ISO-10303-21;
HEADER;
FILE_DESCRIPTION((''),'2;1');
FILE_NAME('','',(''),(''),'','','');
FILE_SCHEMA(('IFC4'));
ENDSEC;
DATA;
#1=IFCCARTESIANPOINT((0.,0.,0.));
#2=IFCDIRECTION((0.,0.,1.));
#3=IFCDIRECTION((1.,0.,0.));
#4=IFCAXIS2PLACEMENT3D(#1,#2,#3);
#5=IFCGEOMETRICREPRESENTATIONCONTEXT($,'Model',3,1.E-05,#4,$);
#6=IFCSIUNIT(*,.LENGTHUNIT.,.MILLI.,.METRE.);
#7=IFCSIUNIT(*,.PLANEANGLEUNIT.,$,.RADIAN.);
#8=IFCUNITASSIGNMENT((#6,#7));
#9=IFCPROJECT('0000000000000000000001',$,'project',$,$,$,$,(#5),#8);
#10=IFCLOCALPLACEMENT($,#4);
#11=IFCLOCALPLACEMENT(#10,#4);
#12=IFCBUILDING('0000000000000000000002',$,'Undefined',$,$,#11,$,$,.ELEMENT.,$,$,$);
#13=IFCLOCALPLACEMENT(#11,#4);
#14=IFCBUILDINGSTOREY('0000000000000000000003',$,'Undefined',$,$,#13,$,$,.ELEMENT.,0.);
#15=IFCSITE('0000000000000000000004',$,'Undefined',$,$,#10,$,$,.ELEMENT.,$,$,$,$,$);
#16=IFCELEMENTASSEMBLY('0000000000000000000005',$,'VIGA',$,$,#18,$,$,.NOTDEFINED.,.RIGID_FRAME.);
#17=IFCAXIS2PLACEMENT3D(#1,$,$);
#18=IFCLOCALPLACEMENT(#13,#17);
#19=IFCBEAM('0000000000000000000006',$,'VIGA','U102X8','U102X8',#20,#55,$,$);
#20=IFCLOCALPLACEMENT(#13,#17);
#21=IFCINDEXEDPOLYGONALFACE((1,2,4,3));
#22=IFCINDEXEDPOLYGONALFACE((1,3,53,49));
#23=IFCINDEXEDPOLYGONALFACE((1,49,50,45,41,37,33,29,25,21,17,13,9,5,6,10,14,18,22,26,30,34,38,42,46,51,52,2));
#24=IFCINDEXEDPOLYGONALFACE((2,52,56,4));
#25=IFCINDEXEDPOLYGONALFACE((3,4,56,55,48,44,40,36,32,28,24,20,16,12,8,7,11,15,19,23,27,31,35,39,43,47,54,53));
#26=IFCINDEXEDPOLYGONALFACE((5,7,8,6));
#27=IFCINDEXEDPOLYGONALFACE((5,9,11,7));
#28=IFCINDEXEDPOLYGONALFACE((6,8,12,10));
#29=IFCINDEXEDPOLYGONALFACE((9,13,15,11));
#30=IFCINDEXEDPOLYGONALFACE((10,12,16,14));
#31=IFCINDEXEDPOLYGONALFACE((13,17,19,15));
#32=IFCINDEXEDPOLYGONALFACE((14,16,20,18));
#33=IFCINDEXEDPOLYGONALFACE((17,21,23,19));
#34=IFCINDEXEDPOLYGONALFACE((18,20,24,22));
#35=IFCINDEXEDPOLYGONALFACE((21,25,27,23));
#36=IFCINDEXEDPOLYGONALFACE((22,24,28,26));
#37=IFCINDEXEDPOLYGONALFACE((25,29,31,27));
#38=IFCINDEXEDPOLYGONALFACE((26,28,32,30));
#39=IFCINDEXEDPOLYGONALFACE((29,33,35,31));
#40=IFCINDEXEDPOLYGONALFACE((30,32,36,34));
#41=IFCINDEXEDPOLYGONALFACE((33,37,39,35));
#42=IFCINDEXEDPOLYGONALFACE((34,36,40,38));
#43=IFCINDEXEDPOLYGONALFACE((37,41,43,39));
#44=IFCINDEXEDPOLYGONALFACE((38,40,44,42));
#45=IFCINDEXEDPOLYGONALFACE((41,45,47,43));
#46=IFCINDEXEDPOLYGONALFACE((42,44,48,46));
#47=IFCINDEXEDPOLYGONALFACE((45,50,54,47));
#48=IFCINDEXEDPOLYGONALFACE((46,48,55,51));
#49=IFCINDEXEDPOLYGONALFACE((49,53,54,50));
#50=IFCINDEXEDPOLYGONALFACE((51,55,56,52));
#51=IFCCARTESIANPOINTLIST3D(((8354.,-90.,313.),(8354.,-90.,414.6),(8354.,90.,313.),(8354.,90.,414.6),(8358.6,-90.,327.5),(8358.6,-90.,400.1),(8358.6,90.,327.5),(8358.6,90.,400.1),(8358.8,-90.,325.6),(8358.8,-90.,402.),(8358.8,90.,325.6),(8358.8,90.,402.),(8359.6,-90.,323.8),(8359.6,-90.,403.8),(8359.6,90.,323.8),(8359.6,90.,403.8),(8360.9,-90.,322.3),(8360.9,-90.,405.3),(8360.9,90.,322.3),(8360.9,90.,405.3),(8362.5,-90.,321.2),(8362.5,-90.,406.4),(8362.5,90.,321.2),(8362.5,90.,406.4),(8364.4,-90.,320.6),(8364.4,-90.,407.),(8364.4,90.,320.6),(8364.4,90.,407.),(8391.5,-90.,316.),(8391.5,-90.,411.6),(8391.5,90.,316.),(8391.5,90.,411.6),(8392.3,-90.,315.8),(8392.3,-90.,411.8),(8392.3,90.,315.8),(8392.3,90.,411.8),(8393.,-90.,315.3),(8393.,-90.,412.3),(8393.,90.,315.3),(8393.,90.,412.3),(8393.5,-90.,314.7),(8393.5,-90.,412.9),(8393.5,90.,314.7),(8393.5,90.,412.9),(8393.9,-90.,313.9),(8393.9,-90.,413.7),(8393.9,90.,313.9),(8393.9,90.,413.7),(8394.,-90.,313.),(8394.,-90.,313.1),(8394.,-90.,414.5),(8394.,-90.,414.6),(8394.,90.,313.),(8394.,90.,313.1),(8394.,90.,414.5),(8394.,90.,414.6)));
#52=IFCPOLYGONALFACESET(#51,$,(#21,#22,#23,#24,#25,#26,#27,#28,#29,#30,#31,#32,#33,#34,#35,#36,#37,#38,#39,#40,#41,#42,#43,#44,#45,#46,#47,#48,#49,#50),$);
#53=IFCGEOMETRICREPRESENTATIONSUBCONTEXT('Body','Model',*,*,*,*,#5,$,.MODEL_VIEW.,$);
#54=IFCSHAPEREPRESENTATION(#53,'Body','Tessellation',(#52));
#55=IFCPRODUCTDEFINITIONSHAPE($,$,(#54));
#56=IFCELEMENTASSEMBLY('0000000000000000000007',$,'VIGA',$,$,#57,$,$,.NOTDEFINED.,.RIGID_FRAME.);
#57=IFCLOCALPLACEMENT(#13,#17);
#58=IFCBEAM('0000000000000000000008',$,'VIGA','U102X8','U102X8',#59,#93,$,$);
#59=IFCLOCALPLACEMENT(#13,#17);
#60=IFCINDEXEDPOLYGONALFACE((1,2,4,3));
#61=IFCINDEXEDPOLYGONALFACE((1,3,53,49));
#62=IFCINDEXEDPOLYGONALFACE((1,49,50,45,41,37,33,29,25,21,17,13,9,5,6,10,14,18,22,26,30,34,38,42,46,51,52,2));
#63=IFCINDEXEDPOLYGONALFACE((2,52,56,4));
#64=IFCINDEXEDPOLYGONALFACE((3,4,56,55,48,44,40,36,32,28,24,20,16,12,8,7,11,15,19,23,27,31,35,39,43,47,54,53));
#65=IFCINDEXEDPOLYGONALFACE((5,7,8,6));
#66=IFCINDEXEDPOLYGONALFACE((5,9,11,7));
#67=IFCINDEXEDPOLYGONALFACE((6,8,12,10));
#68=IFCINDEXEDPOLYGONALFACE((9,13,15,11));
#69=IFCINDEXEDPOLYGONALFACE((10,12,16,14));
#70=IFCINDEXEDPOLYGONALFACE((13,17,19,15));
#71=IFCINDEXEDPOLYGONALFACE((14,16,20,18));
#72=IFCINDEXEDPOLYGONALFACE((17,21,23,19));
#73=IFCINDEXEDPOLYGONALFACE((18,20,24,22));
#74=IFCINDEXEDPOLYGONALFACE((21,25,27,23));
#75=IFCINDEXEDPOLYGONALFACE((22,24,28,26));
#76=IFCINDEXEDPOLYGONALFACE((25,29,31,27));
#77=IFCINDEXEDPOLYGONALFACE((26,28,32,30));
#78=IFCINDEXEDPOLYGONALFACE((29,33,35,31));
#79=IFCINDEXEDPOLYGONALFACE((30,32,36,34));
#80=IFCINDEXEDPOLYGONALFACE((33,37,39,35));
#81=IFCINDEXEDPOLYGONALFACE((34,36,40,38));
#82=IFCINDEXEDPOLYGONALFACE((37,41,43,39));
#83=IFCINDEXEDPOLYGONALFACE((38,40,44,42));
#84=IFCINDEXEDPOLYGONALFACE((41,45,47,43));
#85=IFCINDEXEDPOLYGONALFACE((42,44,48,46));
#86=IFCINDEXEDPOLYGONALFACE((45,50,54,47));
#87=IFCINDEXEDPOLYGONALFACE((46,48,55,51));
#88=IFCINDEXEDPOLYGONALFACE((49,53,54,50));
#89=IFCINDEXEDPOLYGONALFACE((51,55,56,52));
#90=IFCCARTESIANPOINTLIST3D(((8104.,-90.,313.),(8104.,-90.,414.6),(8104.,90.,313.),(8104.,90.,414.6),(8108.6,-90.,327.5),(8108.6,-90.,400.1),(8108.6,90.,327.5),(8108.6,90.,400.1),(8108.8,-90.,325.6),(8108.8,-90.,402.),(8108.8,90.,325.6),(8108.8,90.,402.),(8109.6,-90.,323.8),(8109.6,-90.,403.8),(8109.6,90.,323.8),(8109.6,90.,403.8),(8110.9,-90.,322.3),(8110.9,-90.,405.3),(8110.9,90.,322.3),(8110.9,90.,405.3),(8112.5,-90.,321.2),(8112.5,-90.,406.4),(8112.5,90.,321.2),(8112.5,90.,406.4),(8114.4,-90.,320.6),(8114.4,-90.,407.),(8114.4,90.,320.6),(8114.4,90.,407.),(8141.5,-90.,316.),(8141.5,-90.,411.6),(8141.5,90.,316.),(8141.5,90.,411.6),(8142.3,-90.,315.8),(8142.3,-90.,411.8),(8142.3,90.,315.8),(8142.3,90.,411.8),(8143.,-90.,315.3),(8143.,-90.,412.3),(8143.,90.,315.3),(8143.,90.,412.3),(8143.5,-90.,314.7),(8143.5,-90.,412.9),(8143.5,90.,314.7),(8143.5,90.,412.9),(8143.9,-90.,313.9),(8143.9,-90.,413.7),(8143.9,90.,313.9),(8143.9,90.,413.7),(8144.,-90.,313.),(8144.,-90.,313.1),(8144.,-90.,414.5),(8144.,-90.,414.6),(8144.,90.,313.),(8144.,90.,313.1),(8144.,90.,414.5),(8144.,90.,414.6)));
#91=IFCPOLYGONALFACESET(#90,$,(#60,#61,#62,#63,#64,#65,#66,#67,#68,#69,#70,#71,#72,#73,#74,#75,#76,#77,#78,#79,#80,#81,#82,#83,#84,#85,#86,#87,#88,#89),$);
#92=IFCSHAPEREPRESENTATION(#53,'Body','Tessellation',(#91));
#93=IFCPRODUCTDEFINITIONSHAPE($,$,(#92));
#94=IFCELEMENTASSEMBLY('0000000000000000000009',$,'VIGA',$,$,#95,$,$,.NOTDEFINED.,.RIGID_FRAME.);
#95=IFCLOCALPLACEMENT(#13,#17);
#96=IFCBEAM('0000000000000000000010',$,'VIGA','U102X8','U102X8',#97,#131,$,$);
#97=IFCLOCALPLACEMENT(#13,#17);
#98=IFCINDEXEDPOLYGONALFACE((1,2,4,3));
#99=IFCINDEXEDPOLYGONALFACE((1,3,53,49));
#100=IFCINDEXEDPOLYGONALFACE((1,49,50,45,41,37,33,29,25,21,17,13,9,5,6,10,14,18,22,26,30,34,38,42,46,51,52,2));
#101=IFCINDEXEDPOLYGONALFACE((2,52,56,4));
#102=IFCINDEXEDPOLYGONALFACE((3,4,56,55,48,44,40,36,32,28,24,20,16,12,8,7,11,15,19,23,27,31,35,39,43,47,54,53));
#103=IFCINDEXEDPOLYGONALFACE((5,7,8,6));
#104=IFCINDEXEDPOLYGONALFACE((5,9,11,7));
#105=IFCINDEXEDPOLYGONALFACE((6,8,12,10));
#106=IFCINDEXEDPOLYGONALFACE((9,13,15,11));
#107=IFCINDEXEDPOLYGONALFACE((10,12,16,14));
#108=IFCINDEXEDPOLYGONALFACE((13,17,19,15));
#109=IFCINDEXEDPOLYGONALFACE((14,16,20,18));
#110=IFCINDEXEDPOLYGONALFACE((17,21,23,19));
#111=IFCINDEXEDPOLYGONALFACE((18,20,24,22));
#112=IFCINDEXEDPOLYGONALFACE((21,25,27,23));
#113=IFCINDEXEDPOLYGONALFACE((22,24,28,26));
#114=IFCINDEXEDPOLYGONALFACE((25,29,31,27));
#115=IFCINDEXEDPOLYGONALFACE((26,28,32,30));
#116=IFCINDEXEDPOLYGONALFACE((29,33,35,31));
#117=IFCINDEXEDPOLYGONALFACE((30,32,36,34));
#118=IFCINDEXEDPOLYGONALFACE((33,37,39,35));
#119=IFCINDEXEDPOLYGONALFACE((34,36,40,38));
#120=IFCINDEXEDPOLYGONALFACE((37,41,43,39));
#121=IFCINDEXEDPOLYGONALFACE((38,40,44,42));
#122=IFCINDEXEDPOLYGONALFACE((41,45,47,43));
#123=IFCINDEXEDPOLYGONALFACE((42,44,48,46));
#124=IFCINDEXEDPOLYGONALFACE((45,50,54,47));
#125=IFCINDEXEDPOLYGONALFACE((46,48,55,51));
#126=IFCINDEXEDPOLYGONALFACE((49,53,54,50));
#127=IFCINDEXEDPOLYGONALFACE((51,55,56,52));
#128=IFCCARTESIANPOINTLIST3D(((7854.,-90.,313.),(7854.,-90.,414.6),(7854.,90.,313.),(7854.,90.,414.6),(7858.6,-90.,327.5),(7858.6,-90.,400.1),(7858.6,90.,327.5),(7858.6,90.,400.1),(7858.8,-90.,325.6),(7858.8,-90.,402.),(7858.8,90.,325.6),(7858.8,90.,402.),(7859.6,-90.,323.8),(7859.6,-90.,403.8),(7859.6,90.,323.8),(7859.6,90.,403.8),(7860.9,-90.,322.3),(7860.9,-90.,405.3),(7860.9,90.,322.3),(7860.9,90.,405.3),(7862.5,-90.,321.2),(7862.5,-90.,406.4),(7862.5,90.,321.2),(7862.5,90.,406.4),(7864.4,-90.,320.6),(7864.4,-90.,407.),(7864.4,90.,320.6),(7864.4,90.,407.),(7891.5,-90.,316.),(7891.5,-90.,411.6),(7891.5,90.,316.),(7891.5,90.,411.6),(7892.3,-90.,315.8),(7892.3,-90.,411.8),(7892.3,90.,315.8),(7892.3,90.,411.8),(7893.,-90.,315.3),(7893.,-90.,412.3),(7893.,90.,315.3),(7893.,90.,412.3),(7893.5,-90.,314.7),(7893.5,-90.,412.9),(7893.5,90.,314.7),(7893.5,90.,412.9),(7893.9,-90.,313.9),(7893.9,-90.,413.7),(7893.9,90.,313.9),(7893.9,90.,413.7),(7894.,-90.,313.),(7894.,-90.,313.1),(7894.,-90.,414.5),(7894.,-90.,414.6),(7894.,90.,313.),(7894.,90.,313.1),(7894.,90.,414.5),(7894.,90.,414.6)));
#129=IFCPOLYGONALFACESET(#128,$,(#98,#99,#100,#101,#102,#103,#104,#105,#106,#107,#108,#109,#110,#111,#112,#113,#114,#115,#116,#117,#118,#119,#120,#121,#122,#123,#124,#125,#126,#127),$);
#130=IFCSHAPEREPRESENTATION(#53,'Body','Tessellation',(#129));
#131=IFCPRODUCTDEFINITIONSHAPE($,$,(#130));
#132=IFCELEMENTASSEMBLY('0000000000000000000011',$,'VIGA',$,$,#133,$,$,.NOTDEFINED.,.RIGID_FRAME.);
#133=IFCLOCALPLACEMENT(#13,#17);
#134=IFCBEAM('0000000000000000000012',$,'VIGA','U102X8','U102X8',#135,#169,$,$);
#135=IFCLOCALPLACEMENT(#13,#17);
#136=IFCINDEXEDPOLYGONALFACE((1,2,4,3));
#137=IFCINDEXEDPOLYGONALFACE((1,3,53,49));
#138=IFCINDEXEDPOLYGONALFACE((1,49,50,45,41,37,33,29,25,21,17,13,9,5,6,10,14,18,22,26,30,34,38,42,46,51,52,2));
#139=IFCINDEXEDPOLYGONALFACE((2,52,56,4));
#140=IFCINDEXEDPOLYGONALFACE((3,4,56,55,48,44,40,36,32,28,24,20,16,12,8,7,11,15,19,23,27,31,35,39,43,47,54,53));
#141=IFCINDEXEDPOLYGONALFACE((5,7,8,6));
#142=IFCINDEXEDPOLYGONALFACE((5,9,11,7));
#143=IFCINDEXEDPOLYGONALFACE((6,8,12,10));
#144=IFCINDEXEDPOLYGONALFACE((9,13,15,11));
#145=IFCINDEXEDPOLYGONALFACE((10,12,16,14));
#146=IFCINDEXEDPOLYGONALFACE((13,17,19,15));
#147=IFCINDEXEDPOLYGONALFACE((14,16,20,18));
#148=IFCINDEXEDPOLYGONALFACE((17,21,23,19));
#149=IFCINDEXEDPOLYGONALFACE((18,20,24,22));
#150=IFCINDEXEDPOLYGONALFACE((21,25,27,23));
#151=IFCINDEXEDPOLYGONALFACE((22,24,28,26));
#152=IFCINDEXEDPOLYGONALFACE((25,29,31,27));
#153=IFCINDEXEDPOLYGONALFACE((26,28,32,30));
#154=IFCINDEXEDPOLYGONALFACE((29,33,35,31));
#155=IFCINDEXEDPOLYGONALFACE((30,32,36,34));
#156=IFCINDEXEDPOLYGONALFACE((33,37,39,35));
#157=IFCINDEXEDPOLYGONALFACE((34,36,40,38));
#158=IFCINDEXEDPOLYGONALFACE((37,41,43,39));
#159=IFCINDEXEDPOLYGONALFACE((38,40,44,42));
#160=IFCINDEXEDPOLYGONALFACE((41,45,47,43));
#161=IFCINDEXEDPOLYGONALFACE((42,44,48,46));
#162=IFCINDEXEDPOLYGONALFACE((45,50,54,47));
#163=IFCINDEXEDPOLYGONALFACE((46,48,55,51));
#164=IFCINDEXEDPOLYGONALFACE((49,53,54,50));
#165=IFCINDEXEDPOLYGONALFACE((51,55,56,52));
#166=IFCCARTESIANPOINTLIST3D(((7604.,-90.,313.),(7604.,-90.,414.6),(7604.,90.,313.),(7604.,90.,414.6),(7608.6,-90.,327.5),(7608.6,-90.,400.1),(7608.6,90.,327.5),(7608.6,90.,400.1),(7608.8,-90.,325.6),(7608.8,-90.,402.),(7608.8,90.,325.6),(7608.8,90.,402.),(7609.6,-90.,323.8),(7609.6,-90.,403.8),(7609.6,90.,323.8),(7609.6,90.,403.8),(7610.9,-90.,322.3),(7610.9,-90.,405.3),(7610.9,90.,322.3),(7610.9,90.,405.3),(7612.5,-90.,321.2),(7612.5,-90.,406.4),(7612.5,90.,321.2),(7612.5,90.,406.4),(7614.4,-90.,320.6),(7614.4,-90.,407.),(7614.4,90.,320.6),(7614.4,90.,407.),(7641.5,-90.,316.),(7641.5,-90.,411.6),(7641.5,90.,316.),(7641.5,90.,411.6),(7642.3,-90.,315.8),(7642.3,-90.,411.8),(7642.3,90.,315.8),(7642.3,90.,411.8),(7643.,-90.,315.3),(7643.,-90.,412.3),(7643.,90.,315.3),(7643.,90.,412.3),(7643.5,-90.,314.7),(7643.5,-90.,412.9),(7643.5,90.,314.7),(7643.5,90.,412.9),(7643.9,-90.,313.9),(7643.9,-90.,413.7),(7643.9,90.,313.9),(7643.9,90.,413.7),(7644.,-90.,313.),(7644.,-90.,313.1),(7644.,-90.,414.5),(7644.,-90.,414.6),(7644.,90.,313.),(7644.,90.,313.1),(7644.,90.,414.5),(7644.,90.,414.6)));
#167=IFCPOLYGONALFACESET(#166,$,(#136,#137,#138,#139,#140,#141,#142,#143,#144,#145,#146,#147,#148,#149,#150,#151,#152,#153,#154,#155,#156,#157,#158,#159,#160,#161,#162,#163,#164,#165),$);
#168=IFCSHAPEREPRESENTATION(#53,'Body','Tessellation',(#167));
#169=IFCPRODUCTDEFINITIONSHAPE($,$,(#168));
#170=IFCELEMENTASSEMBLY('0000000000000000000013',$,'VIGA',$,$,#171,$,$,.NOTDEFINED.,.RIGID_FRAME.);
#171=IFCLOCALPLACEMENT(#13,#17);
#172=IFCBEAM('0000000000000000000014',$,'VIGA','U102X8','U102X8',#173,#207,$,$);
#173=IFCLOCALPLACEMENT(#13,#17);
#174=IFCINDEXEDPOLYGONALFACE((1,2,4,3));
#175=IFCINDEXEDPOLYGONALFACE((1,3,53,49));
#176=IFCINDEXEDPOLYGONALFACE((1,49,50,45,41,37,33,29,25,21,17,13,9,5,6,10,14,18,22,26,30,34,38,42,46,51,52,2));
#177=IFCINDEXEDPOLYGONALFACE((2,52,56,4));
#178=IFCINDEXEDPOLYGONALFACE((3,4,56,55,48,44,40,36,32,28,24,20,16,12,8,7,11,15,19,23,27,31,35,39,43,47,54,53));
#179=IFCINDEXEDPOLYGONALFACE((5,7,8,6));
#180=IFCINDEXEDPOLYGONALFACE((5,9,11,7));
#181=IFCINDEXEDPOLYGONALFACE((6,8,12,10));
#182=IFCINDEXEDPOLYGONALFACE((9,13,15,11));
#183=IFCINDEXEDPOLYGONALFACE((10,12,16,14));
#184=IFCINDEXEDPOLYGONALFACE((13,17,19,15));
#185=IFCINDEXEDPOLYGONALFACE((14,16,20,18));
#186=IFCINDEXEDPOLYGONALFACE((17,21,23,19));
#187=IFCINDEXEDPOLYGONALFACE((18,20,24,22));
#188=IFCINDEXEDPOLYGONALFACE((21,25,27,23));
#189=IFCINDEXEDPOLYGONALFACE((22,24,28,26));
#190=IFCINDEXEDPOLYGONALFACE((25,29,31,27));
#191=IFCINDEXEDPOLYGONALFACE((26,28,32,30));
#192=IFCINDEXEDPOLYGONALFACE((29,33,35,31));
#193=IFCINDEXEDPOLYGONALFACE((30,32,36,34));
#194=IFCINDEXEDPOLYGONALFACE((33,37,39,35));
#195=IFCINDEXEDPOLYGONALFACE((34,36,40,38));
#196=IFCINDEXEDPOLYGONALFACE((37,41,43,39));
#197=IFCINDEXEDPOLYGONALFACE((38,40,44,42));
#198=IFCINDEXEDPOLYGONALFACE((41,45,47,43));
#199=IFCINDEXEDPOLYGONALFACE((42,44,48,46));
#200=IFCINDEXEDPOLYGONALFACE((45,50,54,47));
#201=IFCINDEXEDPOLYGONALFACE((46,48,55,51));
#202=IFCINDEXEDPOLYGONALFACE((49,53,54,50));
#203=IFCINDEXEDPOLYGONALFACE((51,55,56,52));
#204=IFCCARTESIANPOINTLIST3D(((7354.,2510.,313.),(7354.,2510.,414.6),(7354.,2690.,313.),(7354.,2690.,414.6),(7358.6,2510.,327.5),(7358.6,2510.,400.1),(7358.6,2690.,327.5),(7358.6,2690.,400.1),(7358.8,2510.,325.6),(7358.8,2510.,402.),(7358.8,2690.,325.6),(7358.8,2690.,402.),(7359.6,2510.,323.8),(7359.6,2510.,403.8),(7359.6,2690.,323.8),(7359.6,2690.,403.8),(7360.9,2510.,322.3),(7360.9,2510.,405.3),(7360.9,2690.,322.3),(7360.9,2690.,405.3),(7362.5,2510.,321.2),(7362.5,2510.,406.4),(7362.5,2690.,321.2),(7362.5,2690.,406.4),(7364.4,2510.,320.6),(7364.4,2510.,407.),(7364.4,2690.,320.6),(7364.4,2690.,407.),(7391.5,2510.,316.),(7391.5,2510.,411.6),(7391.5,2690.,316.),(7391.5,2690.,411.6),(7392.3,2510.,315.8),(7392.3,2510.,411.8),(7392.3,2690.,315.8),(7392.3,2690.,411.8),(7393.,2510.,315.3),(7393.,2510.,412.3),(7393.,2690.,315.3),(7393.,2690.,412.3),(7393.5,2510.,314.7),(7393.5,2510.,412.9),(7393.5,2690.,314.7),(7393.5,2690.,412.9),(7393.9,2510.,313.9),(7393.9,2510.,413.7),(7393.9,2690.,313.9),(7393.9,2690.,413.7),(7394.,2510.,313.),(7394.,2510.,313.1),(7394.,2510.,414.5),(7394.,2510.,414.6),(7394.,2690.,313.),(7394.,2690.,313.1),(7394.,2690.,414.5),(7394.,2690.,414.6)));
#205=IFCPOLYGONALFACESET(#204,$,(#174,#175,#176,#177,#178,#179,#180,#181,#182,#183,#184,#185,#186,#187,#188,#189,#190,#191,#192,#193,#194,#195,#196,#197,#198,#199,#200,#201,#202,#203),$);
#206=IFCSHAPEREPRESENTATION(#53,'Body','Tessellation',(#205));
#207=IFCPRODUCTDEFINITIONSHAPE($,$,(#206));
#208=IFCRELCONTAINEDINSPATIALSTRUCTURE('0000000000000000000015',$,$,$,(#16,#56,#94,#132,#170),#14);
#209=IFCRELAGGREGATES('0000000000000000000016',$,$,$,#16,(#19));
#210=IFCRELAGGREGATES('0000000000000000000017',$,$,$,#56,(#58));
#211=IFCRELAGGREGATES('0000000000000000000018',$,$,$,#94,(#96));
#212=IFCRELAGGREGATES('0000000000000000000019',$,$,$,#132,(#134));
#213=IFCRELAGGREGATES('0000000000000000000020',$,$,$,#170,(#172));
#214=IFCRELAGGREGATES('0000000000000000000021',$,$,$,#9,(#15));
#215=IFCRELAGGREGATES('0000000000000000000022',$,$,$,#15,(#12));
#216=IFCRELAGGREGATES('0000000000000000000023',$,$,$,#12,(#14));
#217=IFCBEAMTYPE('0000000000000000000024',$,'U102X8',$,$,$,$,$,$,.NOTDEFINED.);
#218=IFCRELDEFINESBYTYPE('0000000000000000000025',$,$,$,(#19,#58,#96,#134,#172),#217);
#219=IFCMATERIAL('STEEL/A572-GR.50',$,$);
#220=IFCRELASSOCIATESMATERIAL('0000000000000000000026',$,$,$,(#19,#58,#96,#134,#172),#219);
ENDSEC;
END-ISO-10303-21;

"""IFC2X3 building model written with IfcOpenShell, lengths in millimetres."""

from ifc_helpers import new_model, si_unit, frame, origin_with_axes, origin_2d_with_axis, place, context, subcontext, project, spatial, u_section, extrude, material, type_object, element, aggregate, save


model = new_model("IFC2X3")

# Units and contexts
model_context = context("Model", 3, precision=1e-05, world=origin_with_axes())
body_context = subcontext(model_context, "Body", "Model", "MODEL_VIEW")
ifc_project = project(units=[si_unit("LENGTHUNIT", "METRE", prefix="MILLI"), si_unit("PLANEANGLEUNIT", "RADIAN")], contexts=[model_context])

# Site, building, storey
site_placement = place(None, origin_with_axes())
site = spatial("IfcSite", under=ifc_project, at=site_placement, Name="Undefined", CompositionType="ELEMENT")
building_placement = place(site_placement, origin_with_axes())
building = spatial("IfcBuilding", under=site, at=building_placement, Name="Undefined", CompositionType="ELEMENT")
storey_placement = place(building_placement, origin_with_axes())
storey = spatial("IfcBuildingStorey", under=building, at=storey_placement, Name="Undefined", CompositionType="ELEMENT", Elevation=0.0)

# Element assemblies, beams
ifc_material_1 = material(Name="STEEL/A572-GR.50")
beam_type_1 = type_object("IfcBeamType", Name="U102X8", PredefinedType="NOTDEFINED")
assembly_1_placement = place(storey_placement, origin_with_axes())
assembly_1 = element("IfcElementAssembly", 1, at=assembly_1_placement, inside=storey, Name="VIGA", AssemblyPlace="NOTDEFINED", PredefinedType="RIGID_FRAME")
beam_1_placement = place(assembly_1_placement, frame((8374.0, -90.0, 363.8), z_axis=(0.0, 0.0, 1.0), x_axis=(0.0, 1.0, 0.0)))
beam_1 = element("IfcBeam", 2, at=beam_1_placement, type_object=beam_type_1, material=ifc_material_1, Name="VIGA", Description="U102X8", ObjectType="U102X8", context=body_context, shape_type="SweptSolid", body=[
    extrude(u_section(Depth=101.6, FlangeWidth=40.0, WebThickness=4.6, FlangeThickness=6.0, FilletRadius=7.0, EdgeRadius=3.0, FlangeSlope=0.16839, at=origin_2d_with_axis()), frame((180.0, 0.0, 0.0), z_axis=(-1.0, 0.0, 0.0), x_axis=(0.0, -1.0, 0.0)), (0.0, 0.0, 1.0), 180.0),
])
aggregate(assembly_1, [beam_1])
assembly_2_placement = place(storey_placement, origin_with_axes())
assembly_2 = element("IfcElementAssembly", 3, at=assembly_2_placement, inside=storey, Name="VIGA", AssemblyPlace="NOTDEFINED", PredefinedType="RIGID_FRAME")
beam_2_placement = place(assembly_2_placement, frame((8124.0, -90.0, 363.8), z_axis=(0.0, 0.0, 1.0), x_axis=(0.0, 1.0, 0.0)))
beam_2 = element("IfcBeam", 4, at=beam_2_placement, type_object=beam_type_1, material=ifc_material_1, Name="VIGA", Description="U102X8", ObjectType="U102X8", context=body_context, shape_type="SweptSolid", body=[
    extrude(u_section(Depth=101.6, FlangeWidth=40.0, WebThickness=4.6, FlangeThickness=6.0, FilletRadius=7.0, EdgeRadius=3.0, FlangeSlope=0.16839, at=origin_2d_with_axis()), frame((180.0, 0.0, 0.0), z_axis=(-1.0, 0.0, 0.0), x_axis=(0.0, -1.0, 0.0)), (0.0, 0.0, 1.0), 180.0),
])
aggregate(assembly_2, [beam_2])
assembly_3_placement = place(storey_placement, origin_with_axes())
assembly_3 = element("IfcElementAssembly", 5, at=assembly_3_placement, inside=storey, Name="VIGA", AssemblyPlace="NOTDEFINED", PredefinedType="RIGID_FRAME")
beam_3_placement = place(assembly_3_placement, frame((7874.0, -90.0, 363.8), z_axis=(0.0, 0.0, 1.0), x_axis=(0.0, 1.0, 0.0)))
beam_3 = element("IfcBeam", 6, at=beam_3_placement, type_object=beam_type_1, material=ifc_material_1, Name="VIGA", Description="U102X8", ObjectType="U102X8", context=body_context, shape_type="SweptSolid", body=[
    extrude(u_section(Depth=101.6, FlangeWidth=40.0, WebThickness=4.6, FlangeThickness=6.0, FilletRadius=7.0, EdgeRadius=3.0, FlangeSlope=0.16839, at=origin_2d_with_axis()), frame((180.0, 0.0, 0.0), z_axis=(-1.0, 0.0, 0.0), x_axis=(0.0, -1.0, 0.0)), (0.0, 0.0, 1.0), 180.0),
])
aggregate(assembly_3, [beam_3])
assembly_4_placement = place(storey_placement, origin_with_axes())
assembly_4 = element("IfcElementAssembly", 7, at=assembly_4_placement, inside=storey, Name="VIGA", AssemblyPlace="NOTDEFINED", PredefinedType="RIGID_FRAME")
beam_4_placement = place(assembly_4_placement, frame((7624.0, -90.0, 363.8), z_axis=(0.0, 0.0, 1.0), x_axis=(0.0, 1.0, 0.0)))
beam_4 = element("IfcBeam", 8, at=beam_4_placement, type_object=beam_type_1, material=ifc_material_1, Name="VIGA", Description="U102X8", ObjectType="U102X8", context=body_context, shape_type="SweptSolid", body=[
    extrude(u_section(Depth=101.6, FlangeWidth=40.0, WebThickness=4.6, FlangeThickness=6.0, FilletRadius=7.0, EdgeRadius=3.0, FlangeSlope=0.16839, at=origin_2d_with_axis()), frame((180.0, 0.0, 0.0), z_axis=(-1.0, 0.0, 0.0), x_axis=(0.0, -1.0, 0.0)), (0.0, 0.0, 1.0), 180.0),
])
aggregate(assembly_4, [beam_4])
assembly_5_placement = place(storey_placement, origin_with_axes())
assembly_5 = element("IfcElementAssembly", 9, at=assembly_5_placement, inside=storey, Name="VIGA", AssemblyPlace="NOTDEFINED", PredefinedType="RIGID_FRAME")
beam_5_placement = place(assembly_5_placement, frame((7374.0, 2510.0, 363.8), z_axis=(0.0, 0.0, 1.0), x_axis=(0.0, 1.0, 0.0)))
beam_5 = element("IfcBeam", 10, at=beam_5_placement, type_object=beam_type_1, material=ifc_material_1, Name="VIGA", Description="U102X8", ObjectType="U102X8", context=body_context, shape_type="SweptSolid", body=[
    extrude(u_section(Depth=101.6, FlangeWidth=40.0, WebThickness=4.6, FlangeThickness=6.0, FilletRadius=7.0, EdgeRadius=3.0, FlangeSlope=0.16839, at=origin_2d_with_axis()), frame((180.0, 0.0, 0.0), z_axis=(-1.0, 0.0, 0.0), x_axis=(0.0, -1.0, 0.0)), (0.0, 0.0, 1.0), 180.0),
])
aggregate(assembly_5, [beam_5])

save(model, "model.ifc")
